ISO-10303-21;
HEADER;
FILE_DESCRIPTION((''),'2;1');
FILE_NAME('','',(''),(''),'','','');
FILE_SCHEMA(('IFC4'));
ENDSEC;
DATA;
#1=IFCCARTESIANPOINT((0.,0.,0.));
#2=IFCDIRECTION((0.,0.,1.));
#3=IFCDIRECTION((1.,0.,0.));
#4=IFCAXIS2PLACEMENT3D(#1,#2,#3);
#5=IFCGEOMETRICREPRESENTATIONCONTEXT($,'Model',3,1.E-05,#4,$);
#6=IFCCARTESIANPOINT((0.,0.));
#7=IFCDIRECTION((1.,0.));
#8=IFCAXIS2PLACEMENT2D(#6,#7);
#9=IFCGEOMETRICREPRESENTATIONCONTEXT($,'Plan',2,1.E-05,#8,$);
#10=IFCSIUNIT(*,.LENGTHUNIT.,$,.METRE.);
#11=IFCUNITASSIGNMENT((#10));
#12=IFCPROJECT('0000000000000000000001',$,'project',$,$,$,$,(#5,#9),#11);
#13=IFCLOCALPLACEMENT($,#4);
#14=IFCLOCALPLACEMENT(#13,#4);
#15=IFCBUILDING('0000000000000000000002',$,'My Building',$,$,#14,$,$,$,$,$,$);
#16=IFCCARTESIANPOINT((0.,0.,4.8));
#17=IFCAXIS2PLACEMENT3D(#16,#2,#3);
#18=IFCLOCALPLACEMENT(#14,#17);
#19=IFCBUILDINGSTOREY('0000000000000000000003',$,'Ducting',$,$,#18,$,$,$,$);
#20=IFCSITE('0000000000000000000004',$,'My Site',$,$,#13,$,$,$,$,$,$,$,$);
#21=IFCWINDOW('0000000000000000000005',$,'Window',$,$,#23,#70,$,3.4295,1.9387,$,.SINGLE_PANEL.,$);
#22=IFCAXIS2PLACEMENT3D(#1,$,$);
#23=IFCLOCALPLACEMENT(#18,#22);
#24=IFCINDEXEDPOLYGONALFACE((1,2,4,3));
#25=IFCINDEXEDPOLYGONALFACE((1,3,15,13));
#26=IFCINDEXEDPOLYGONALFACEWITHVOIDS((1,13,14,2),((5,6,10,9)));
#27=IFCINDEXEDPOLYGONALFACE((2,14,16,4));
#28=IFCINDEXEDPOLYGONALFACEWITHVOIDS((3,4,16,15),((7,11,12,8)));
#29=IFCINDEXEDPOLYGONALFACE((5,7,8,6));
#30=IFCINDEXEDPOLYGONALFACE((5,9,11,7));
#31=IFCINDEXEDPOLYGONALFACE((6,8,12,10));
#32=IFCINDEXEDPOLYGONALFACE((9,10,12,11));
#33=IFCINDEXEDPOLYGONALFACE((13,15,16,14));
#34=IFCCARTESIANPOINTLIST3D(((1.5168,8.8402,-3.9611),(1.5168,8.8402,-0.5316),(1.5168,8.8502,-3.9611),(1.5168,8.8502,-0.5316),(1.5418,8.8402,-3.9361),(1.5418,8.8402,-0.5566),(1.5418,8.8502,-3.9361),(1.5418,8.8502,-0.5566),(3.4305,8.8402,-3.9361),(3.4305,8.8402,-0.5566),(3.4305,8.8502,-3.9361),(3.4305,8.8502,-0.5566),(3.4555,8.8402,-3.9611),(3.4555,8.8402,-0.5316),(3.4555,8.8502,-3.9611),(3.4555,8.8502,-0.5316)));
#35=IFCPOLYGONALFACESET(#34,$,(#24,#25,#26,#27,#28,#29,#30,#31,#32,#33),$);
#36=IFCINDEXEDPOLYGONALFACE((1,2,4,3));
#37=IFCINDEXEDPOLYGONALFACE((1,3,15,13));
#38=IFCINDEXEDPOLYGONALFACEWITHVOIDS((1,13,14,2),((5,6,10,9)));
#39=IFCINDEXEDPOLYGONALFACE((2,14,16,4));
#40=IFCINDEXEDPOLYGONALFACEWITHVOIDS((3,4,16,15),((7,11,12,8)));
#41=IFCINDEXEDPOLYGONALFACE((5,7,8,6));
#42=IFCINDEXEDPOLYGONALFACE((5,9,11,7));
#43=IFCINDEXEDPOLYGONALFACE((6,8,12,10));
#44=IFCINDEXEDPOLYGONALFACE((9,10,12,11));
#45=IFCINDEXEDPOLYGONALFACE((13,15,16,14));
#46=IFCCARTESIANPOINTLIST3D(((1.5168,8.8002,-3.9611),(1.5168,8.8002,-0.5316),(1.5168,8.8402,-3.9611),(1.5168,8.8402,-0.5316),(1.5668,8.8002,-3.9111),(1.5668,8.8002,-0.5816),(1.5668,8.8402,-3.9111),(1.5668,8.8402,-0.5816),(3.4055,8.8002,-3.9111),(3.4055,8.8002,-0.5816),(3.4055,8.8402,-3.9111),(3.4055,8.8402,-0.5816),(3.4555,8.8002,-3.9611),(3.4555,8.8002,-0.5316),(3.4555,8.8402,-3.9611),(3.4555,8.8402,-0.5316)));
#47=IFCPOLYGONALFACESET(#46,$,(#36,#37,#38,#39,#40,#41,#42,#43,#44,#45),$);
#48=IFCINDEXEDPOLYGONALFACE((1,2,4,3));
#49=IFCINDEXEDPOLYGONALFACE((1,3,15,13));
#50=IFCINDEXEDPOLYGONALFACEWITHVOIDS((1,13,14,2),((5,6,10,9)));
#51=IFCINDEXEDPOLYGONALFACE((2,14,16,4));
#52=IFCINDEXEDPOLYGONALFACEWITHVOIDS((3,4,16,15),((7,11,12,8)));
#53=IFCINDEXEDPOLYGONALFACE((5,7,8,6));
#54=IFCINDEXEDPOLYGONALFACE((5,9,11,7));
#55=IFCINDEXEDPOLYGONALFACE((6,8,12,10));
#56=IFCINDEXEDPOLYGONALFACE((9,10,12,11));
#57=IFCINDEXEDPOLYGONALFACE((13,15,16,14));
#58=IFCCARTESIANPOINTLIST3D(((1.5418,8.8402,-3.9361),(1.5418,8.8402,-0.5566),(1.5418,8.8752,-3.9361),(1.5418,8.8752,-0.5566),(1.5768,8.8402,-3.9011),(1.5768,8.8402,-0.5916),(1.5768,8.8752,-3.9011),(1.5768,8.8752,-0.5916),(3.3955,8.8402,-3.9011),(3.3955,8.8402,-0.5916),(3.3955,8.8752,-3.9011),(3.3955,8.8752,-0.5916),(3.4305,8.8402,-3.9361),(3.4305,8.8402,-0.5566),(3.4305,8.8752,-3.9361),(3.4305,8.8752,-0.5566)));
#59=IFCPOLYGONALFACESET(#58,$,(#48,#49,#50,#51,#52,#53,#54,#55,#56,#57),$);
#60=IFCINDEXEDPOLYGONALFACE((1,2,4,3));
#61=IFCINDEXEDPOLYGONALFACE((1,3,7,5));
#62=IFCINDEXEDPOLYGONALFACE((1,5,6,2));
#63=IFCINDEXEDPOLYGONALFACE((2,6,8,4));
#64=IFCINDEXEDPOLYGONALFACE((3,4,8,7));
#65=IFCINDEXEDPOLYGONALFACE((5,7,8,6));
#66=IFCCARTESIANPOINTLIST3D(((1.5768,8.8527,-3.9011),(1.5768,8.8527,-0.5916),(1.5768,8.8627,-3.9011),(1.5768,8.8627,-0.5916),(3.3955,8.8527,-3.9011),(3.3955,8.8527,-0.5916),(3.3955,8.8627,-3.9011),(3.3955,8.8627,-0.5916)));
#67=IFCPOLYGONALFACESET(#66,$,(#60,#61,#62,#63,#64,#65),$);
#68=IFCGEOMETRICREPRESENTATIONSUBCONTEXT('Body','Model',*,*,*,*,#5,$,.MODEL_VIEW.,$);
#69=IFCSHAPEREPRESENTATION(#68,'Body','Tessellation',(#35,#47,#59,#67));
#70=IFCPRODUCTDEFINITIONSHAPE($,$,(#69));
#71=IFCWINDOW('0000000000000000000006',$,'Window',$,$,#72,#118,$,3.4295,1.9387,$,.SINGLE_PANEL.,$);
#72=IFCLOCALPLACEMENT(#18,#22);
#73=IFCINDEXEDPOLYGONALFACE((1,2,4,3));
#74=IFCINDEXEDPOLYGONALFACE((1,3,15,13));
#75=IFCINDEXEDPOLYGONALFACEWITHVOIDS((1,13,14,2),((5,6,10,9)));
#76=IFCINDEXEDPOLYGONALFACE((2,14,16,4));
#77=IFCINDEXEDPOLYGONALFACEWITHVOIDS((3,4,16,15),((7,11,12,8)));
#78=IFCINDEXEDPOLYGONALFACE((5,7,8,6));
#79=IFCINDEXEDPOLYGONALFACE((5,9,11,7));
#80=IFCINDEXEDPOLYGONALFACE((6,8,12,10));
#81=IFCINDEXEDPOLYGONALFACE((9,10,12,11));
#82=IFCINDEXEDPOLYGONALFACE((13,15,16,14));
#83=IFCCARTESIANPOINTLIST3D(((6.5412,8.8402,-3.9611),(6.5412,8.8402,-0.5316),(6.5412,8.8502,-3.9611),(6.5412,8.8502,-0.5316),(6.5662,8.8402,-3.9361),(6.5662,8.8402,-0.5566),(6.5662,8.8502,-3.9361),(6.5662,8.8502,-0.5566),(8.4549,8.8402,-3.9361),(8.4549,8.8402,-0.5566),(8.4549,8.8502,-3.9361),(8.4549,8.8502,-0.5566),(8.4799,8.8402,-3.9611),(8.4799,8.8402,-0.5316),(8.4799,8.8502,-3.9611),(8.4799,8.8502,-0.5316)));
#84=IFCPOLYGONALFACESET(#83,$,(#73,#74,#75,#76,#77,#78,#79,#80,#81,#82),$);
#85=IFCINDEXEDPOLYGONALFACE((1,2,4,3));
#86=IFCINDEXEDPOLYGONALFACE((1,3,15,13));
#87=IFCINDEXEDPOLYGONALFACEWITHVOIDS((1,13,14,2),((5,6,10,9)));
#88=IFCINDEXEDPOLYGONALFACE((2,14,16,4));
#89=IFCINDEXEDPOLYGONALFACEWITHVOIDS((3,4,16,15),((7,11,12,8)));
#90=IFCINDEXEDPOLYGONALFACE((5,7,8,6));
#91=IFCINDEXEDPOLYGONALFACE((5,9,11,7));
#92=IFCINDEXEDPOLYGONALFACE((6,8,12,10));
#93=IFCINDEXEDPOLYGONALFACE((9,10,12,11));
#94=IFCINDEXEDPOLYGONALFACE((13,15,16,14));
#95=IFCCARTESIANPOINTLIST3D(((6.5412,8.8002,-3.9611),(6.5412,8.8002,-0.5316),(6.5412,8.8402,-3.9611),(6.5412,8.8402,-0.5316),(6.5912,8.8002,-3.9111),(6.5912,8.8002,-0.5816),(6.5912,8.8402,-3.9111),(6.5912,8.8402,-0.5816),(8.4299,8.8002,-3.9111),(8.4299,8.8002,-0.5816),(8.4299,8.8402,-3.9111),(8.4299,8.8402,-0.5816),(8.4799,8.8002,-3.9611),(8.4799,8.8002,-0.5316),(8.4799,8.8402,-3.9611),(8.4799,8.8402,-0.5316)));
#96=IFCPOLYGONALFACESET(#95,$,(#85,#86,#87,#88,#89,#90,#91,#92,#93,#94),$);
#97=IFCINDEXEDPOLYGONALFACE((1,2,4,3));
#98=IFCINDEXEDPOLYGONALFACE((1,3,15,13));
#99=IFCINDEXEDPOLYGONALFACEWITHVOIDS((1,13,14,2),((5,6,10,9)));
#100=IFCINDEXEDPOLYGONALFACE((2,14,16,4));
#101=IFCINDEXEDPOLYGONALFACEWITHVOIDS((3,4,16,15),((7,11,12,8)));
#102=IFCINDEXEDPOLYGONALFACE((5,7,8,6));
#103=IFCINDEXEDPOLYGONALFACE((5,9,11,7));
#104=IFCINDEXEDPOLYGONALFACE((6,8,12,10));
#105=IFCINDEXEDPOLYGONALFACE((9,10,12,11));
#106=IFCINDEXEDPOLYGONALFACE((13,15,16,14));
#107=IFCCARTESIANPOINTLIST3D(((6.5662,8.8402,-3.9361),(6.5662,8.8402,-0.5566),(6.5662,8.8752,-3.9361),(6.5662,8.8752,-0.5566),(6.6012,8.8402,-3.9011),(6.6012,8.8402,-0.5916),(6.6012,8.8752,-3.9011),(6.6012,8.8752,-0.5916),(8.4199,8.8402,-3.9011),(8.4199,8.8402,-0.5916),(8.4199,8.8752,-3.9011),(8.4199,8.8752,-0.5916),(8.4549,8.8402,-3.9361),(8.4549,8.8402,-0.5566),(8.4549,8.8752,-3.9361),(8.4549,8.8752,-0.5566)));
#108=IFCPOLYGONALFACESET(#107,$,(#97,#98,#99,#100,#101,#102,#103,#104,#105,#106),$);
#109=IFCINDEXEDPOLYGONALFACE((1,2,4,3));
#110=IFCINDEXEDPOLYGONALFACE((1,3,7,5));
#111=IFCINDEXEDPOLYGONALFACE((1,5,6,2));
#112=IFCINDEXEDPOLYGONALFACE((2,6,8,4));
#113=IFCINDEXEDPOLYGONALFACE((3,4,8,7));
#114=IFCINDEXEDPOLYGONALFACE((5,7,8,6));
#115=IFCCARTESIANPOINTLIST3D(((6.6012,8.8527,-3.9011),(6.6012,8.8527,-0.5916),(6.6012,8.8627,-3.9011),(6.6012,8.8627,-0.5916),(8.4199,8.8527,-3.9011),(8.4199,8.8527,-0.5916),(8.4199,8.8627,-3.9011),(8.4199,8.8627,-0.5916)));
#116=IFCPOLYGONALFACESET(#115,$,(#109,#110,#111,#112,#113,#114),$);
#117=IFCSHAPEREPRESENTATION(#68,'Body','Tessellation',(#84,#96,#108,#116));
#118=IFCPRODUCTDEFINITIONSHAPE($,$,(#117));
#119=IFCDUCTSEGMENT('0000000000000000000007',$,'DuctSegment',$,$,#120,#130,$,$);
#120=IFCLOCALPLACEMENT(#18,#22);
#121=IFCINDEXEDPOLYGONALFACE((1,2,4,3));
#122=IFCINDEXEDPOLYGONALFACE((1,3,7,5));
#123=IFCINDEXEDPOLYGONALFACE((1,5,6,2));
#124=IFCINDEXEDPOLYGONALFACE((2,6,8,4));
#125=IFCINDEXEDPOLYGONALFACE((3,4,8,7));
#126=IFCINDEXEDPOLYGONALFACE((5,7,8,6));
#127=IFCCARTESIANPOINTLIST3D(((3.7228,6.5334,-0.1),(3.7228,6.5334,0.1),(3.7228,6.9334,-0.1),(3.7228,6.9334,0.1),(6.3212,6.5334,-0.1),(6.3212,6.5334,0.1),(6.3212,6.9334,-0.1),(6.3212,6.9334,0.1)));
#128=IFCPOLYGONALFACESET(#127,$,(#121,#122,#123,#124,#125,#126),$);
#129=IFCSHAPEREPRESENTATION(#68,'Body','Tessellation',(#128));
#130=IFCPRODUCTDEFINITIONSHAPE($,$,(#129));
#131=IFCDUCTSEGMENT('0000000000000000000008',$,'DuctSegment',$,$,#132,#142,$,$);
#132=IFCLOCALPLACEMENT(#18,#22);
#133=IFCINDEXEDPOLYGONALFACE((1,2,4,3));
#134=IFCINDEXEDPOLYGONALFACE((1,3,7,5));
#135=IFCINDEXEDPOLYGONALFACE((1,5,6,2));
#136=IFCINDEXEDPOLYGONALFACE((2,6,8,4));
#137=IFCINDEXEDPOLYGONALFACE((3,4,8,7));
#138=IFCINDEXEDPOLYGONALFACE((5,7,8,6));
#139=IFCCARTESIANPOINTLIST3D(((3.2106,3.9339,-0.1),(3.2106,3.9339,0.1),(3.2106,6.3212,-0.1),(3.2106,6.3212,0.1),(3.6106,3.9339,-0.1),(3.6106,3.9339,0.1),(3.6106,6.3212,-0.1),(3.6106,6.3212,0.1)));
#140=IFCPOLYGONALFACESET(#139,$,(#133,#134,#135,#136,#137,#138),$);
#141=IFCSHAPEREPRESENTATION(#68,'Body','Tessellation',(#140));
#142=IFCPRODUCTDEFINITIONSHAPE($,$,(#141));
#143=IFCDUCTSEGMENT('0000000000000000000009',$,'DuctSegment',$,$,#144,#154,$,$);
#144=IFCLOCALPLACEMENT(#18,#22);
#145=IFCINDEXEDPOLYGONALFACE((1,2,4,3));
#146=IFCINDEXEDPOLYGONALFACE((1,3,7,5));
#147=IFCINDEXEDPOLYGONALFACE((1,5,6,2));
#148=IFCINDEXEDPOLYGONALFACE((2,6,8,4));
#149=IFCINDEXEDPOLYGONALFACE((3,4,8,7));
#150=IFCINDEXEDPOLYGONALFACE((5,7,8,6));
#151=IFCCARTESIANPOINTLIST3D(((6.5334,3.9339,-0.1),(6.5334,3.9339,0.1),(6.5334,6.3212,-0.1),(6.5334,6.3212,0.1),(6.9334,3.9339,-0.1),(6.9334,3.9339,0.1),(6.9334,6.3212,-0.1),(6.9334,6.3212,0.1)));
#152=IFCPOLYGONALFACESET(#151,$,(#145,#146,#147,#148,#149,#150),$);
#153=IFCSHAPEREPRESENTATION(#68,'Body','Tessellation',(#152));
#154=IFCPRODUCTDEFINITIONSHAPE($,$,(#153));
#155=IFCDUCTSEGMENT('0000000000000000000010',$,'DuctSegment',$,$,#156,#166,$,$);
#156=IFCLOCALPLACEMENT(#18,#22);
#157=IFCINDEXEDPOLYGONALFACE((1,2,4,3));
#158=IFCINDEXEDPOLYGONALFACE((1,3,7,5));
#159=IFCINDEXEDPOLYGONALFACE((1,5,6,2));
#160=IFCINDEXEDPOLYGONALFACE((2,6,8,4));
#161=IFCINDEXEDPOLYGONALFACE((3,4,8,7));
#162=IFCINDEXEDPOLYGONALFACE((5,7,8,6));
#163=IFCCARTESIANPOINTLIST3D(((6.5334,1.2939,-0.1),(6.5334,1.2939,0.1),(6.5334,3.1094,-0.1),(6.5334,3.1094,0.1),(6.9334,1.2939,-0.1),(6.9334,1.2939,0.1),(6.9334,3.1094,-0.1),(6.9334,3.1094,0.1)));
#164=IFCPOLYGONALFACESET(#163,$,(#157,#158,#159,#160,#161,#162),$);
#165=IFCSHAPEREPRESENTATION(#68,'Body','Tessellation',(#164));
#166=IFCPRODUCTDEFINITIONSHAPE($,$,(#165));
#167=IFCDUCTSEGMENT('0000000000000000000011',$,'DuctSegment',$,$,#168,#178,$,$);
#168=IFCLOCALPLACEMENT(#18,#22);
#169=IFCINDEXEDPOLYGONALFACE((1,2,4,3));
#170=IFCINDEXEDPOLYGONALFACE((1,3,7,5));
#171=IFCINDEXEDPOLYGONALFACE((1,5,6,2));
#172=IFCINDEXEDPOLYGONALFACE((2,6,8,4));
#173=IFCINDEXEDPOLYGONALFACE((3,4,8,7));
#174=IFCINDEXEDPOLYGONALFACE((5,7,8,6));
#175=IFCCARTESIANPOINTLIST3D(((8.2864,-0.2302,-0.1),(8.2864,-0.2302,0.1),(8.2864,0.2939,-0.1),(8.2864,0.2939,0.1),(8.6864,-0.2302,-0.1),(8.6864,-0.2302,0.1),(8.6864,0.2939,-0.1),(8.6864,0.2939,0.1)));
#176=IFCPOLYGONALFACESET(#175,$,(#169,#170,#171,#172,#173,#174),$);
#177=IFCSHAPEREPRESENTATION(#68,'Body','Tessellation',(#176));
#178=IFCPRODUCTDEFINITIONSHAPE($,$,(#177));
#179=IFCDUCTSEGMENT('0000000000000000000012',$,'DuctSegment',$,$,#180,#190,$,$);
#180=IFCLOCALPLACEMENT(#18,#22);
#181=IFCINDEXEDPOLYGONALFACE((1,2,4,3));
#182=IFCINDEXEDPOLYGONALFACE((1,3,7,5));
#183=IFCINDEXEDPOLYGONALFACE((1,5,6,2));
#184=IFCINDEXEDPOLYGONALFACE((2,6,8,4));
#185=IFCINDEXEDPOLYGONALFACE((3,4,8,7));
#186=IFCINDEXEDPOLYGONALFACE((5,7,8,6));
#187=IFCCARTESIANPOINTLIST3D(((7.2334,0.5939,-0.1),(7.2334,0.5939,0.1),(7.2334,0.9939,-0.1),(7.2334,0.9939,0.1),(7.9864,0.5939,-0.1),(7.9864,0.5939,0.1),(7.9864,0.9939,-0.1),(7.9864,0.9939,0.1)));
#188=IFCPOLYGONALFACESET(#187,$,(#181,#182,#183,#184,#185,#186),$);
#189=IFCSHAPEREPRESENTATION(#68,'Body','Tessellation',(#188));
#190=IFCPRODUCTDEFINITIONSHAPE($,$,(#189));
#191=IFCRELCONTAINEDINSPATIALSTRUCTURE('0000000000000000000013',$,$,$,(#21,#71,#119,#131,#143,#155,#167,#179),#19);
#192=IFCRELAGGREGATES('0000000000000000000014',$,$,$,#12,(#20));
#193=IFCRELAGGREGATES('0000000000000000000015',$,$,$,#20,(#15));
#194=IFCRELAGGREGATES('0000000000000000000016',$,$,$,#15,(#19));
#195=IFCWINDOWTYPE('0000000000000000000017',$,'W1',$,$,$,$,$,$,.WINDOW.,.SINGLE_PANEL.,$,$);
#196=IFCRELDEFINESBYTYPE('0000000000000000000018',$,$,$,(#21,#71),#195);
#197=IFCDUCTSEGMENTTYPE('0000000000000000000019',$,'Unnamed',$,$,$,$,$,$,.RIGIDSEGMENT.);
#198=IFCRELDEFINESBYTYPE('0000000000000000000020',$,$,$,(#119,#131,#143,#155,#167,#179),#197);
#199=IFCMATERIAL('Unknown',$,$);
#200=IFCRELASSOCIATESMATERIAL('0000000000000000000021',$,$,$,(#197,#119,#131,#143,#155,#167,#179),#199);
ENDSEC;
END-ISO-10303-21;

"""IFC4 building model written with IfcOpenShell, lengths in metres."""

from ifc_helpers import new_model, entity, si_unit, frame, origin_with_axes, origin_2d_with_axis, place, context, subcontext, project, spatial, line, indexed_curve, rectangle, outline, extrude, shape, source, transform, mapped, material, material_profile, profile_set, profile_usage, type_object, type_shapes, element, save


model = new_model("IFC4")

# Units and contexts
model_context = context("Model", 3, precision=1e-05, world=origin_with_axes())
plan_context = context("Plan", 2, precision=1e-05, world=origin_2d_with_axis())
body_context_1 = subcontext(model_context, "Body", "Model", "MODEL_VIEW")
body_context_2 = subcontext(plan_context, "Body", "Plan", "PLAN_VIEW")
ifc_project = project(units=[si_unit("LENGTHUNIT", "METRE")], contexts=[model_context, plan_context])

# Site, building, storey
site_placement = place(None, origin_with_axes())
site = spatial("IfcSite", under=ifc_project, at=site_placement, Name="My Site")
building_placement = place(site_placement, origin_with_axes())
building = spatial("IfcBuilding", under=site, at=building_placement, Name="My Building")
storey_placement = place(building_placement, frame((0.0, 0.0, 4.8), z_axis=(0.0, 0.0, 1.0), x_axis=(1.0, 0.0, 0.0)))
storey = spatial("IfcBuildingStorey", under=building, at=storey_placement, Name="Ducting")

# Shared definitions
ifc_material = material(Name="Unknown")

# Windows
window_type = type_object("IfcWindowType", Name="W1", PartitioningType="SINGLE_PANEL", PredefinedType="WINDOW")
shared_shape_1 = source(origin_with_axes(), body_context_1, "Body", "SweptSolid", [
    extrude(outline(indexed_curve([(0.0, 0.0), (1.9387, 0.0), (1.9387, 3.4295), (0.0, 3.4295)], segments=[line(1, 2, 3, 4, 1)]), holes=[indexed_curve([(0.025, 0.025), (1.9137, 0.025), (1.9137, 3.4045), (0.025, 3.4045)], segments=[line(1, 2, 3, 4, 1)])]), frame((0.0, 0.09, 0.0), z_axis=(0.0, -1.0, 0.0), x_axis=(1.0, 0.0, 0.0)), (0.0, 0.0, -1.0), 0.01),
    extrude(outline(indexed_curve([(0.0, 0.0), (1.9387, 0.0), (1.9387, 3.4295), (0.0, 3.4295)], segments=[line(1, 2, 3, 4, 1)]), holes=[indexed_curve([(0.05, 0.05), (1.8887, 0.05), (1.8887, 3.3795), (0.05, 3.3795)], segments=[line(1, 2, 3, 4, 1)])]), frame((0.0, 0.05, 0.0), z_axis=(0.0, -1.0, 0.0), x_axis=(1.0, 0.0, 0.0)), (0.0, 0.0, -1.0), 0.04),
    extrude(outline(indexed_curve([(0.0, 0.0), (1.8887, 0.0), (1.8887, 3.3795), (0.0, 3.3795)], segments=[line(1, 2, 3, 4, 1)]), holes=[indexed_curve([(0.035, 0.035), (1.8537, 0.035), (1.8537, 3.3445), (0.035, 3.3445)], segments=[line(1, 2, 3, 4, 1)])]), frame((0.025, 0.09, 0.025), z_axis=(0.0, -1.0, 0.0), x_axis=(1.0, 0.0, 0.0)), (0.0, 0.0, -1.0), 0.035),
    extrude(outline(indexed_curve([(0.035, 0.035), (1.8537, 0.035), (1.8537, 3.3445), (0.035, 3.3445)], segments=[line(1, 2, 3, 4, 1)])), frame((0.025, 0.1025, 0.025), z_axis=(0.0, -1.0, 0.0), x_axis=(1.0, 0.0, 0.0)), (0.0, 0.0, -1.0), 0.01),
])
shared_shape_2 = source(origin_with_axes(), body_context_2, "Body", "Curve2D", [
    entity("IfcIndexedPolyCurve", entity("IfcCartesianPointList2D", [[0.05, 0.05], [1.8887, 0.05]])),
    entity("IfcIndexedPolyCurve", entity("IfcCartesianPointList2D", [[0.0, 0.1], [0.025, 0.1], [0.025, 0.09], [0.05, 0.09], [0.05, 0.05], [0.0, 0.05]]), [entity("IfcLineIndex", [1, 2, 3, 4, 5, 6, 1])]),
    entity("IfcIndexedPolyCurve", entity("IfcCartesianPointList2D", [[1.9387, 0.1], [1.9137, 0.1], [1.9137, 0.09], [1.8887, 0.09], [1.8887, 0.05], [1.9387, 0.05]]), [entity("IfcLineIndex", [1, 2, 3, 4, 5, 6, 1])]),
    entity("IfcIndexedPolyCurve", entity("IfcCartesianPointList2D", [[0.025, 0.09], [0.06, 0.09], [0.06, 0.125], [0.025, 0.125]]), [entity("IfcLineIndex", [1, 2, 3, 4, 1])]),
    entity("IfcIndexedPolyCurve", entity("IfcCartesianPointList2D", [[1.9137, 0.09], [1.8787, 0.09], [1.8787, 0.125], [1.9137, 0.125]]), [entity("IfcLineIndex", [1, 2, 3, 4, 1])]),
    entity("IfcIndexedPolyCurve", entity("IfcCartesianPointList2D", [[0.06, 0.09], [1.8787, 0.09]])),
    entity("IfcIndexedPolyCurve", entity("IfcCartesianPointList2D", [[0.06, 0.125], [1.8787, 0.125]])),
    entity("IfcIndexedPolyCurve", entity("IfcCartesianPointList2D", [[0.06, 0.1075], [1.8787, 0.1075]])),
])
type_shapes(window_type, [shared_shape_1, shared_shape_2])
for number, where, z_axis, x_axis, name in (
    (1, (1.5168, 8.7502, -3.9611), (0.0, 0.0, 1.0), (1.0, 0.0, 0.0), "Window"),
    (2, (6.5412, 8.7502, -3.9611), (0.0, 0.0, 1.0), (1.0, 0.0, 0.0), "Window"),
):
    element("IfcWindow", number, at=place(storey_placement, frame(where, z_axis=z_axis, x_axis=x_axis)), inside=storey, type_object=window_type, Name=name, OverallHeight=3.4295, OverallWidth=1.9387, PartitioningType="SINGLE_PANEL", shapes=[
        shape(body_context_1, "Body", "MappedRepresentation", [mapped(shared_shape_1, transform((0.0, 0.0, 0.0), x_axis=(1.0, 0.0, 0.0), y_axis=(0.0, 1.0, 0.0), z_axis=(0.0, 0.0, 1.0), scale=1.0))]),
        shape(body_context_2, "Body", "MappedRepresentation", [mapped(shared_shape_2, transform((0.0, 0.0, 0.0), x_axis=(1.0, 0.0, 0.0), y_axis=(0.0, 1.0, 0.0), z_axis=(0.0, 0.0, 1.0), scale=1.0))]),
    ])

# Duct segments
ifc_material_profile_1 = material_profile(ifc_material, rectangle(XDim=0.4, YDim=0.2))
ifc_profile_set_1 = profile_set([ifc_material_profile_1])
ifc_profile_usage_1 = profile_usage(ifc_profile_set_1, cardinal=5)
duct_segment_type = type_object("IfcDuctSegmentType", Name="Unnamed", PredefinedType="RIGIDSEGMENT", material=ifc_profile_set_1)
duct_segment_1_placement = place(storey_placement, frame((3.7228, 6.7334, 0.0), z_axis=(1.0, 0.0, 0.0), x_axis=(0.0, 1.0, 0.0)))
element("IfcDuctSegment", 3, at=duct_segment_1_placement, inside=storey, type_object=duct_segment_type, material=ifc_profile_usage_1, Name="DuctSegment", context=body_context_1, shape_type="SweptSolid", body=[
    extrude(rectangle(XDim=0.4, YDim=0.2), origin_with_axes(), (0.0, 0.0, 1.0), 2.5983),
])
ifc_profile_usage_2 = profile_usage(ifc_profile_set_1, cardinal=5)
duct_segment_2_placement = place(storey_placement, frame((3.4106, 6.3212, 0.0), z_axis=(0.0, -1.0, 0.0), x_axis=(1.0, 0.0, 0.0)))
element("IfcDuctSegment", 4, at=duct_segment_2_placement, inside=storey, type_object=duct_segment_type, material=ifc_profile_usage_2, Name="DuctSegment", context=body_context_1, shape_type="SweptSolid", body=[
    extrude(rectangle(XDim=0.4, YDim=0.2), origin_with_axes(), (0.0, 0.0, 1.0), 2.3873),
])
ifc_profile_usage_3 = profile_usage(ifc_profile_set_1, cardinal=5)
duct_segment_3_placement = place(storey_placement, frame((6.7334, 6.3212, 0.0), z_axis=(0.0, -1.0, 0.000001), x_axis=(1.0, 0.0, 0.0)))
element("IfcDuctSegment", 5, at=duct_segment_3_placement, inside=storey, type_object=duct_segment_type, material=ifc_profile_usage_3, Name="DuctSegment", context=body_context_1, shape_type="SweptSolid", body=[
    extrude(rectangle(XDim=0.4, YDim=0.2), origin_with_axes(), (0.0, 0.0, 1.0), 2.3873),
])
ifc_profile_usage_4 = profile_usage(ifc_profile_set_1, cardinal=5)
duct_segment_4_placement = place(storey_placement, frame((6.7334, 3.1094, 0.0), z_axis=(0.0, -1.0, 0.0), x_axis=(1.0, 0.0, 0.0)))
element("IfcDuctSegment", 6, at=duct_segment_4_placement, inside=storey, type_object=duct_segment_type, material=ifc_profile_usage_4, Name="DuctSegment", context=body_context_1, shape_type="SweptSolid", body=[
    extrude(rectangle(XDim=0.4, YDim=0.2), origin_with_axes(), (0.0, 0.0, 1.0), 1.8155),
])
ifc_profile_usage_5 = profile_usage(ifc_profile_set_1, cardinal=5)
duct_segment_5_placement = place(storey_placement, frame((8.4864, -0.2302, 0.0), z_axis=(0.0, 1.0, 0.0), x_axis=(-1.0, 0.0, 0.0)))
element("IfcDuctSegment", 7, at=duct_segment_5_placement, inside=storey, type_object=duct_segment_type, material=ifc_profile_usage_5, Name="DuctSegment", context=body_context_1, shape_type="SweptSolid", body=[
    extrude(rectangle(XDim=0.4, YDim=0.2), origin_with_axes(), (0.0, 0.0, 1.0), 0.5242),
])
ifc_profile_usage_6 = profile_usage(ifc_profile_set_1, cardinal=5)
duct_segment_6_placement = place(storey_placement, frame((7.2334, 0.7939, 0.0), z_axis=(1.0, 0.0, 0.0), x_axis=(0.0, 1.0, 0.0)))
element("IfcDuctSegment", 8, at=duct_segment_6_placement, inside=storey, type_object=duct_segment_type, material=ifc_profile_usage_6, Name="DuctSegment", context=body_context_1, shape_type="SweptSolid", body=[
    extrude(rectangle(XDim=0.4, YDim=0.2), origin_with_axes(), (0.0, 0.0, 1.0), 0.7529),
])

save(model, "model.ifc")
